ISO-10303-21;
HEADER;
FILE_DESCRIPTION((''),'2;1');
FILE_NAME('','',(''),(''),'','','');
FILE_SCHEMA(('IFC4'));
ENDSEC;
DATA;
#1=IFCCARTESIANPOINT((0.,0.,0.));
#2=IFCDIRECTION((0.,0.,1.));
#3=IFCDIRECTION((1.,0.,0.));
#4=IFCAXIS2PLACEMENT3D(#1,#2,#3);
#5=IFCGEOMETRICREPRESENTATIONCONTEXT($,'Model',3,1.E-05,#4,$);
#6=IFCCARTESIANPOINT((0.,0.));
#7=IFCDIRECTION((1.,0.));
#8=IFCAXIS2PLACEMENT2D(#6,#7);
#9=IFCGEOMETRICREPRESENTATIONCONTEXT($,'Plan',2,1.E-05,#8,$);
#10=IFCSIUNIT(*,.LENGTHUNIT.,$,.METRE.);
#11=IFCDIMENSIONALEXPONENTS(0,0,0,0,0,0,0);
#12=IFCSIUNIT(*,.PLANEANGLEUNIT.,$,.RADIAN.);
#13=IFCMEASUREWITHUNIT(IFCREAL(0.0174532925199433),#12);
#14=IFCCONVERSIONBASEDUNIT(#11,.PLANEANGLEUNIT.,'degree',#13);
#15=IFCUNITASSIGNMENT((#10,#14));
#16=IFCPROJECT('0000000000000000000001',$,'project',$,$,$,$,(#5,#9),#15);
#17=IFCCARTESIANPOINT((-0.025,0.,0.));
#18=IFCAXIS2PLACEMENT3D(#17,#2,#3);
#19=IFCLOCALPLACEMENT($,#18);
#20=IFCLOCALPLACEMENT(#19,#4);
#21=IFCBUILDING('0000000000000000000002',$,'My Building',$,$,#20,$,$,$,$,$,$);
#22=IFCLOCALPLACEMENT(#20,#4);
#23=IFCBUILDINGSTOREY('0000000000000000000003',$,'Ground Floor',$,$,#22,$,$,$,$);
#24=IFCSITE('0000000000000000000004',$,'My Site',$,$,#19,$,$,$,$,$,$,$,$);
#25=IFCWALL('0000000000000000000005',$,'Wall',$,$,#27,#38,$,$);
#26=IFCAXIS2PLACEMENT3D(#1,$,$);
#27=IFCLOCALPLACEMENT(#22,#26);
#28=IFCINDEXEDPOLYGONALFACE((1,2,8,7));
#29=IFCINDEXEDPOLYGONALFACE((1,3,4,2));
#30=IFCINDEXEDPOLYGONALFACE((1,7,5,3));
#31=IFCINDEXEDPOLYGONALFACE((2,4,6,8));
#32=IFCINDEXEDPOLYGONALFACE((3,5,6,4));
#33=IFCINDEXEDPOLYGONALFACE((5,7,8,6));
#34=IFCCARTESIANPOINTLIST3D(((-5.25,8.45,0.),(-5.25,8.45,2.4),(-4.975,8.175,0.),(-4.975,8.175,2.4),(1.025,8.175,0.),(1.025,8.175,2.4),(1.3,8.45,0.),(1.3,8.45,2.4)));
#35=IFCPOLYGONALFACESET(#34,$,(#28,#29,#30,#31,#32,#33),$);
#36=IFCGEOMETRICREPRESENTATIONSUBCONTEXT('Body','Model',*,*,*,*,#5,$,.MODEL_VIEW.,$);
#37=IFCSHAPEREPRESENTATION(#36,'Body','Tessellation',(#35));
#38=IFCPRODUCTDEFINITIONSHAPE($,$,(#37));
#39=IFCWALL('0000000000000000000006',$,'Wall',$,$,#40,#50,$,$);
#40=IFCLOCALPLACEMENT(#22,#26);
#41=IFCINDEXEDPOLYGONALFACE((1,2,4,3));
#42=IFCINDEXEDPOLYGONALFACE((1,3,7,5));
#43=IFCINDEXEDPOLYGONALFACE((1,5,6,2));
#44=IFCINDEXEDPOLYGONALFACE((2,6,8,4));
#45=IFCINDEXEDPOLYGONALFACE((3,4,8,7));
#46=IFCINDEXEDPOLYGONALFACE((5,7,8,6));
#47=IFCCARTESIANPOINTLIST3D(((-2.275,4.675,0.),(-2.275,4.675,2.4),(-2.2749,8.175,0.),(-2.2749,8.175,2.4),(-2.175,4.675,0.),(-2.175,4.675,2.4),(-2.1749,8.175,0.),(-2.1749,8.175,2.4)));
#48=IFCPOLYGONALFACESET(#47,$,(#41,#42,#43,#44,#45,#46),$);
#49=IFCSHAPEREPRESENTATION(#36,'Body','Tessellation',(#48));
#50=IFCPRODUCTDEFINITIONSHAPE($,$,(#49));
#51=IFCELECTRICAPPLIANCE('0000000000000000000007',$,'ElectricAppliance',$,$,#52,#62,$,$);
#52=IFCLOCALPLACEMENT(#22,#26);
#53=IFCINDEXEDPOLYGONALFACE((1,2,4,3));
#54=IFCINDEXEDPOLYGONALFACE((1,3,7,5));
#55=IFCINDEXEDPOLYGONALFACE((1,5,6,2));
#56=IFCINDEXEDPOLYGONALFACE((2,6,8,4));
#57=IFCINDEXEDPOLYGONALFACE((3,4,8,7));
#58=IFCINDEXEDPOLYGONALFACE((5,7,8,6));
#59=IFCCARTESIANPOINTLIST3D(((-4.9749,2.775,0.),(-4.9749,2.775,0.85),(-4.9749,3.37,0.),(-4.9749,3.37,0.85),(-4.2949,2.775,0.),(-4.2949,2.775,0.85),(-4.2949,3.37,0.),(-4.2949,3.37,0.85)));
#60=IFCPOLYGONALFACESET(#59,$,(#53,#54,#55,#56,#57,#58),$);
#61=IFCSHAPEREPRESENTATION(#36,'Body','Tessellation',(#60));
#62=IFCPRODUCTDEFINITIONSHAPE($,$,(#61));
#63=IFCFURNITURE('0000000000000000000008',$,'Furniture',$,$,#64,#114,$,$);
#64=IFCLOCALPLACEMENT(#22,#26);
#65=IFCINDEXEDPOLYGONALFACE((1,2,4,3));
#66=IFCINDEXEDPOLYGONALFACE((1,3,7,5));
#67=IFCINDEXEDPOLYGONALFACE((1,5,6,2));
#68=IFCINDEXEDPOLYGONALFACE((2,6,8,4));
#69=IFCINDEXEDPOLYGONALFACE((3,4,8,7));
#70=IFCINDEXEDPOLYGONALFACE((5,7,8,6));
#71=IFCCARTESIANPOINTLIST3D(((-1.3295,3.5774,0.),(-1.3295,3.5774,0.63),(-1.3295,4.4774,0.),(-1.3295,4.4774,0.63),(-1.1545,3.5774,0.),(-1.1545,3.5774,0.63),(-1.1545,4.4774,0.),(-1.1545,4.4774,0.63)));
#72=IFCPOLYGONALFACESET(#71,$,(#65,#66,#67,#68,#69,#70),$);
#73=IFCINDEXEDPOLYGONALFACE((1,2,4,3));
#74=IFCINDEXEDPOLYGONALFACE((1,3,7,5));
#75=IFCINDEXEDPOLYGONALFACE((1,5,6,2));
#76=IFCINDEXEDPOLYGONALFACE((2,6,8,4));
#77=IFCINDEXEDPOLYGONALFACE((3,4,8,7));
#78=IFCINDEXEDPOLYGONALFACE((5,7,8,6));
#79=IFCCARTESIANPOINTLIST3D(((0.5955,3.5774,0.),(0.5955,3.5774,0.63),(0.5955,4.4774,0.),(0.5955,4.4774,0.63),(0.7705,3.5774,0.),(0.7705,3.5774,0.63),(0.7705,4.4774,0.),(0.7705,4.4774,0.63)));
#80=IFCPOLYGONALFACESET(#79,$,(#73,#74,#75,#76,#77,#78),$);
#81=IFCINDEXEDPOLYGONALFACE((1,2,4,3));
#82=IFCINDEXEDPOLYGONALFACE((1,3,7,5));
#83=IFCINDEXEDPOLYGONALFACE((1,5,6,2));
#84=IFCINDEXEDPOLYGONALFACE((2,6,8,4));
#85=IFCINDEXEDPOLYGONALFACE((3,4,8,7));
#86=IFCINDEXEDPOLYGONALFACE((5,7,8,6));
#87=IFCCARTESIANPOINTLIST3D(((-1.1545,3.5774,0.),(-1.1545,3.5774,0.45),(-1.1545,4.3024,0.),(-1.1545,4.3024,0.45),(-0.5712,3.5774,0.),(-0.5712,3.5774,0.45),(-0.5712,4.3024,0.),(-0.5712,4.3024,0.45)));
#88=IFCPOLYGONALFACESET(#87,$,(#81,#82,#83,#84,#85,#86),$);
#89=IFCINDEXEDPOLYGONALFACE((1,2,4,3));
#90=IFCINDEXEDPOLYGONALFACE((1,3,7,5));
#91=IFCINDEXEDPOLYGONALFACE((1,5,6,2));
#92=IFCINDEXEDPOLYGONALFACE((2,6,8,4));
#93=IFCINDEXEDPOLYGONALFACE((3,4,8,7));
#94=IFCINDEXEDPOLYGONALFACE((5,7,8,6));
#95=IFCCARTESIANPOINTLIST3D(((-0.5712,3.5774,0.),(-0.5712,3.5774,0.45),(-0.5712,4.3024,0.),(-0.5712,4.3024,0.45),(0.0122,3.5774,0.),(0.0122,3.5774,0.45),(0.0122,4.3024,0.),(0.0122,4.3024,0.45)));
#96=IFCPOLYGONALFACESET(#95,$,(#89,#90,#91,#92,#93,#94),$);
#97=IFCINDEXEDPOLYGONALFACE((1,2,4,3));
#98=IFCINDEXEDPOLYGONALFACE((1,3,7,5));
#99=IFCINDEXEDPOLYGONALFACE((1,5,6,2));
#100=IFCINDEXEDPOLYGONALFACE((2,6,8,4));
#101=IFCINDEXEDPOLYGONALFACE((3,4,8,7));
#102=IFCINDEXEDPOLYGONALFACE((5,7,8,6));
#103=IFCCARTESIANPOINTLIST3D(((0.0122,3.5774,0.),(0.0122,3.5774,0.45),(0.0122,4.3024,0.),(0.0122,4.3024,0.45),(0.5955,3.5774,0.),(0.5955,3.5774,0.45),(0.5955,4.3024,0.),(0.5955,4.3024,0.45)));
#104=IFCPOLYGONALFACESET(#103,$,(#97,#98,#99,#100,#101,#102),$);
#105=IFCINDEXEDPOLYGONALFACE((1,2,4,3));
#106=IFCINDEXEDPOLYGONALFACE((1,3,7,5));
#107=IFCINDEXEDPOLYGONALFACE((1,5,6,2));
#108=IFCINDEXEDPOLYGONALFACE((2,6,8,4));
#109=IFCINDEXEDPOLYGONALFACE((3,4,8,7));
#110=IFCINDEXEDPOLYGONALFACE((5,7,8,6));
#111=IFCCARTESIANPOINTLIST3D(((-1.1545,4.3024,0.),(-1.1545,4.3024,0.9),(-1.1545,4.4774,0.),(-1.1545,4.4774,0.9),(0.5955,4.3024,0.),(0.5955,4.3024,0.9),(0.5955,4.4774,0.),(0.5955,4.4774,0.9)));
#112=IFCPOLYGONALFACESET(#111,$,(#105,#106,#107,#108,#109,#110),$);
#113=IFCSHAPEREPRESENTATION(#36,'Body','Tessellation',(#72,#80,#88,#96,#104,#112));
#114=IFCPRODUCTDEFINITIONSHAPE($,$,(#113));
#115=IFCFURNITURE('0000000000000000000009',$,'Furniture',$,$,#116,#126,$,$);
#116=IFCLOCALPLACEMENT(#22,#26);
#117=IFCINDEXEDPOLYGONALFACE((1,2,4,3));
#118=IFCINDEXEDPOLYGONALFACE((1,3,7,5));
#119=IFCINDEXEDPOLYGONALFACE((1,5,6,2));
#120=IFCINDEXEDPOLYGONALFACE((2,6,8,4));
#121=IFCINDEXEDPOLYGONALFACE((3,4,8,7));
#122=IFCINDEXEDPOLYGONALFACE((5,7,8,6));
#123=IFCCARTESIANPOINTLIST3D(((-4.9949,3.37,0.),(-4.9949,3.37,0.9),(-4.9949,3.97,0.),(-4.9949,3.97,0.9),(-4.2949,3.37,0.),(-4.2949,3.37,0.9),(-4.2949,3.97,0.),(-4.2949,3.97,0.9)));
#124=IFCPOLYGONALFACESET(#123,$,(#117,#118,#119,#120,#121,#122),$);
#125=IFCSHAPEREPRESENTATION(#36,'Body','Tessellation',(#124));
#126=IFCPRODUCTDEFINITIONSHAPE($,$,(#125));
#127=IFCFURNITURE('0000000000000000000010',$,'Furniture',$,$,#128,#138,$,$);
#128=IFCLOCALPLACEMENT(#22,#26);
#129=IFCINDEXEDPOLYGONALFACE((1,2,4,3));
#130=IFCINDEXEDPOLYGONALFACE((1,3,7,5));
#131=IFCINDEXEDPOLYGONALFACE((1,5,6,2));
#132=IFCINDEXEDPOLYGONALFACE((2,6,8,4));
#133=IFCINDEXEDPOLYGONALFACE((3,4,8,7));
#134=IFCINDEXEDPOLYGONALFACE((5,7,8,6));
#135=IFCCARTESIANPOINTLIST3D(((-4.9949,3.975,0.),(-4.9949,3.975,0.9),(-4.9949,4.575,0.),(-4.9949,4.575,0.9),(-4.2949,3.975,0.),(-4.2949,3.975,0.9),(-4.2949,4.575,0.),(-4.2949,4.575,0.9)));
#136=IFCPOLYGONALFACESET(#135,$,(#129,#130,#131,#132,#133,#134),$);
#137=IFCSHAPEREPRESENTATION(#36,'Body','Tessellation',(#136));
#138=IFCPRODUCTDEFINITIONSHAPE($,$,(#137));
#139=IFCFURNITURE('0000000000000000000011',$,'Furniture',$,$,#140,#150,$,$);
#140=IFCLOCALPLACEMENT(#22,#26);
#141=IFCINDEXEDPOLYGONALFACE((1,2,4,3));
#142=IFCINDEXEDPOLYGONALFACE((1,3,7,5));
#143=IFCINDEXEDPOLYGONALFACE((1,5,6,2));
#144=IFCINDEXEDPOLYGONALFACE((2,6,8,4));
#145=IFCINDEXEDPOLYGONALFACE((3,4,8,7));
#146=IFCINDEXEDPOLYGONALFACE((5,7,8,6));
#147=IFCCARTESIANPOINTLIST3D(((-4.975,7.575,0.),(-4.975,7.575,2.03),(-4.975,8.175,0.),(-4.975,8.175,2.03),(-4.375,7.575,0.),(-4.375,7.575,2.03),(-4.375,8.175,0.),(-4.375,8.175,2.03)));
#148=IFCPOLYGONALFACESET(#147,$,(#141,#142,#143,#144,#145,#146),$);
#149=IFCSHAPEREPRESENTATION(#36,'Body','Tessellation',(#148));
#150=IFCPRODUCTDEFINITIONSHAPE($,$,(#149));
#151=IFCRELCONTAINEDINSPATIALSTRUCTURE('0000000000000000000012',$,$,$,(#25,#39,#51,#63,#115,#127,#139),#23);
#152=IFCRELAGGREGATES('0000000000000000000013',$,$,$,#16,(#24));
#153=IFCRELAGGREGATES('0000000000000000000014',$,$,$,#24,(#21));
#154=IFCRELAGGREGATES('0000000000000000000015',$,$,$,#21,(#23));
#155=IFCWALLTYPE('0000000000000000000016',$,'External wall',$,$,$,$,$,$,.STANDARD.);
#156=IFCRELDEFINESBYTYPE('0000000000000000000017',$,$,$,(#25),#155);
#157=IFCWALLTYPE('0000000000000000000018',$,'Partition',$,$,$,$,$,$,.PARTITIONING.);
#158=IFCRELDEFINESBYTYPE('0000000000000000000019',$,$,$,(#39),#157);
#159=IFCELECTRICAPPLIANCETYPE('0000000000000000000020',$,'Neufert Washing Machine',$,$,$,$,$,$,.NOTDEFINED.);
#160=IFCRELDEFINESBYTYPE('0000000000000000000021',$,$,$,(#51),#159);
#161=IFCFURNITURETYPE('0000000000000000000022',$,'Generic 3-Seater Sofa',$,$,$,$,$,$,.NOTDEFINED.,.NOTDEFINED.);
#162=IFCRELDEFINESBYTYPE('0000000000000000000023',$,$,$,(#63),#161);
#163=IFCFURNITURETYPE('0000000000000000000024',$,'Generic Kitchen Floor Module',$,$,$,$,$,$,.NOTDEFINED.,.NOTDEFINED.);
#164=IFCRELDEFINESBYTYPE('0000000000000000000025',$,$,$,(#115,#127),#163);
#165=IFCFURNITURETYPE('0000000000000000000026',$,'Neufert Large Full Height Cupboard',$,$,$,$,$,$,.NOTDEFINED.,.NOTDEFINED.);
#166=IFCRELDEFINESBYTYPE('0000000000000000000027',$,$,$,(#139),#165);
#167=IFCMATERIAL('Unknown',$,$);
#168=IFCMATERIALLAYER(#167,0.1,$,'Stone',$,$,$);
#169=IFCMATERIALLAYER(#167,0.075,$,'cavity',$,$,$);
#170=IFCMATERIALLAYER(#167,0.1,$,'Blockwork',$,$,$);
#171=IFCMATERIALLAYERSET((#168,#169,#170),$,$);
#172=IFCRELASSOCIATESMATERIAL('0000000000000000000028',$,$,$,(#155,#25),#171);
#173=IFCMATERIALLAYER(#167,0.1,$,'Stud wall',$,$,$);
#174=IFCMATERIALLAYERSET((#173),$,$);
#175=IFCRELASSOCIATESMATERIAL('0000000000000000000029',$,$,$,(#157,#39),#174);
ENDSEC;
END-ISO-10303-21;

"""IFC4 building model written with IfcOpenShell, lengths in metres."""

from ifc_helpers import new_model, entity, si_unit, converted_unit, frame, origin_with_axes, origin_2d_with_axis, place, context, subcontext, project, spatial, line, indexed_curve, outline, extrude, clip, halfspace, shape, source, transform, mapped, material, layer, layer_set, layer_usage, type_object, type_shapes, element, save


model = new_model("IFC4")

# Units and contexts
model_context = context("Model", 3, precision=1e-05, world=origin_with_axes())
plan_context = context("Plan", 2, precision=1e-05, world=origin_2d_with_axis())
body_context_1 = subcontext(model_context, "Body", "Model", "MODEL_VIEW")
body_context_2 = subcontext(plan_context, "Body", "Plan", "PLAN_VIEW")
ifc_project = project(units=[si_unit("LENGTHUNIT", "METRE"), converted_unit("PLANEANGLEUNIT", "degree", entity("IfcReal", 0.0174532925199433), si_unit("PLANEANGLEUNIT", "RADIAN"), dimensions=[0, 0, 0, 0, 0, 0, 0])], contexts=[model_context, plan_context])

# Site, building, storey
site_placement = place(None, frame((-0.025, 0.0, 0.0), z_axis=(0.0, 0.0, 1.0), x_axis=(1.0, 0.0, 0.0)))
site = spatial("IfcSite", under=ifc_project, at=site_placement, Name="My Site")
building_placement = place(site_placement, origin_with_axes())
building = spatial("IfcBuilding", under=site, at=building_placement, Name="My Building")
storey_placement = place(building_placement, frame((0.0, 0.0, 0.0), z_axis=(0.0, 0.0, 1.0), x_axis=(1.0, 0.0, 0.0)))
storey = spatial("IfcBuildingStorey", under=building, at=storey_placement, Name="Ground Floor")

# Wall
ifc_material = material(Name="Unknown")
ifc_layer_1 = layer(ifc_material, 0.1, Name="Stone")
ifc_layer_2 = layer(ifc_material, 0.075, Name="cavity")
ifc_layer_3 = layer(ifc_material, 0.1, Name="Blockwork")
ifc_layer_set_1 = layer_set([ifc_layer_1, ifc_layer_2, ifc_layer_3])
ifc_layer_usage_1 = layer_usage(ifc_layer_set_1, "AXIS2", "POSITIVE", 0.0)
wall_type_1 = type_object("IfcWallType", Name="External wall", PredefinedType="STANDARD", material=ifc_layer_set_1)
wall_1_placement = place(storey_placement, frame((1.3, 8.45, 0.0), z_axis=(0.0, 0.0, 1.0), x_axis=(-1.0, 0.0, 0.0)))
element("IfcWall", 1, at=wall_1_placement, inside=storey, type_object=wall_type_1, material=ifc_layer_usage_1, Name="Wall", context=body_context_1, shape_type="Clipping", body=[
    clip(clip(extrude(outline(indexed_curve([(0.0, 0.0), (0.0, 0.275), (6.55, 0.275), (6.55, 0.0), (0.0, 0.0)], self_intersect=False)), origin_with_axes(), (0.0, 0.0, 1.0), 2.4), halfspace(frame((6.55, 0.0, 0.0), z_axis=(0.707106, 0.707107, 0.0), x_axis=(0.707107, -0.707106, 0.0)), False)), halfspace(frame((0.0, 0.0, 0.0), z_axis=(-0.707106, 0.707107, 0.0), x_axis=(0.707108, 0.707106, 0.0)), False)),
])

# Shared definitions
ifc_layer_4 = layer(ifc_material, 0.1, Name="Stud wall")
ifc_layer_set_2 = layer_set([ifc_layer_4])
wall_type_2 = type_object("IfcWallType", Name="Partition", PredefinedType="PARTITIONING", material=ifc_layer_set_2)

# Wall
ifc_layer_usage_2 = layer_usage(ifc_layer_set_2, "AXIS2", "POSITIVE", 0.0)
wall_2_placement = place(storey_placement, frame((-2.175, 4.675, 0.0), z_axis=(0.0, 0.0, 1.0), x_axis=(0.0, 1.0, 0.0)))
element("IfcWall", 2, at=wall_2_placement, inside=storey, type_object=wall_type_2, material=ifc_layer_usage_2, Name="Wall", context=body_context_1, shape_type="SweptSolid", body=[
    extrude(outline(indexed_curve([(0.0, 0.0), (0.0, 0.1), (3.5, 0.1), (3.5, 0.0), (0.0, 0.0)], self_intersect=False)), origin_with_axes(), (0.0, 0.0, 1.0), 2.4),
])

# Electric appliance
electric_appliance_type_1 = type_object("IfcElectricApplianceType", Name="Neufert Washing Machine", PredefinedType="NOTDEFINED")
shared_shape_1 = source(origin_with_axes(), body_context_1, "Body", "SweptSolid", [
    extrude(outline(indexed_curve([(0.0, 0.0), (0.595, 0.0), (0.595, 0.68), (0.0, 0.68)], segments=[line(1, 2, 3, 4, 1)])), origin_with_axes(), (0.0, 0.0, 1.0), 0.85),
])
shared_shape_2 = source(origin_with_axes(), body_context_2, "Body", "Curve2D", [
    entity("IfcIndexedPolyCurve", entity("IfcCartesianPointList2D", [[0.0, 0.0], [0.595, 0.0], [0.595, 0.68], [0.0, 0.68]]), [entity("IfcLineIndex", [1, 2, 3, 4, 1])]),
    entity("IfcCircle", entity("IfcAxis2Placement2D", entity("IfcCartesianPoint", [0.2975, 0.34])), 0.1785),
    entity("IfcCircle", entity("IfcAxis2Placement2D", entity("IfcCartesianPoint", [0.2975, 0.34])), 0.0595),
])
type_shapes(electric_appliance_type_1, [shared_shape_1, shared_shape_2])
electric_appliance_1_placement = place(storey_placement, frame((-4.2949, 2.775, 0.0), z_axis=(0.0, 0.0, 1.0), x_axis=(0.0, 1.0, 0.0)))
element("IfcElectricAppliance", 3, at=electric_appliance_1_placement, inside=storey, type_object=electric_appliance_type_1, Name="ElectricAppliance", shapes=[
    shape(body_context_1, "Body", "MappedRepresentation", [mapped(shared_shape_1, transform((0.0, 0.0, 0.0), x_axis=(1.0, 0.0, 0.0), y_axis=(0.0, 1.0, 0.0), z_axis=(0.0, 0.0, 1.0), scale=1.0))]),
    shape(body_context_2, "Body", "MappedRepresentation", [mapped(shared_shape_2, transform((0.0, 0.0, 0.0), x_axis=(1.0, 0.0, 0.0), y_axis=(0.0, 1.0, 0.0), z_axis=(0.0, 0.0, 1.0), scale=1.0))]),
])

# Furniture
furniture_type_1 = type_object("IfcFurnitureType", Name="Generic 3-Seater Sofa", AssemblyPlace="NOTDEFINED", PredefinedType="NOTDEFINED")
shared_shape_3 = source(origin_with_axes(), body_context_1, "Body", "SweptSolid", [
    extrude(outline(indexed_curve([(0.0, 0.0), (0.175, 0.0), (0.175, 0.9), (0.0, 0.9)], segments=[line(1, 2, 3, 4, 1)])), frame((-1.05, -0.9, 0.0), z_axis=(0.0, 0.0, 1.0), x_axis=(1.0, 0.0, 0.0)), (0.0, 0.0, 1.0), 0.63),
    extrude(outline(indexed_curve([(0.0, 0.0), (0.175, 0.0), (0.175, 0.9), (0.0, 0.9)], segments=[line(1, 2, 3, 4, 1)])), frame((0.875, -0.9, 0.0), z_axis=(0.0, 0.0, 1.0), x_axis=(1.0, 0.0, 0.0)), (0.0, 0.0, 1.0), 0.63),
    extrude(outline(indexed_curve([(0.175, 0.0), (0.7583, 0.0), (0.7583, 0.725), (0.175, 0.725)], segments=[line(1, 2, 3, 4, 1)])), frame((-1.05, -0.9, 0.0), z_axis=(0.0, 0.0, 1.0), x_axis=(1.0, 0.0, 0.0)), (0.0, 0.0, 1.0), 0.45),
    extrude(outline(indexed_curve([(0.7583, 0.0), (1.3417, 0.0), (1.3417, 0.725), (0.7583, 0.725)], segments=[line(1, 2, 3, 4, 1)])), frame((-1.05, -0.9, 0.0), z_axis=(0.0, 0.0, 1.0), x_axis=(1.0, 0.0, 0.0)), (0.0, 0.0, 1.0), 0.45),
    extrude(outline(indexed_curve([(1.3417, 0.0), (1.925, 0.0), (1.925, 0.725), (1.3417, 0.725)], segments=[line(1, 2, 3, 4, 1)])), frame((-1.05, -0.9, 0.0), z_axis=(0.0, 0.0, 1.0), x_axis=(1.0, 0.0, 0.0)), (0.0, 0.0, 1.0), 0.45),
    extrude(outline(indexed_curve([(0.175, 0.725), (1.925, 0.725), (1.925, 0.9), (0.175, 0.9)], segments=[line(1, 2, 3, 4, 1)])), frame((-1.05, -0.9, 0.0), z_axis=(0.0, 0.0, 1.0), x_axis=(1.0, 0.0, 0.0)), (0.0, 0.0, 1.0), 0.9),
])
shared_shape_4 = source(origin_with_axes(), body_context_2, "Body", "Curve2D", [
    entity("IfcIndexedPolyCurve", entity("IfcCartesianPointList2D", [[-1.05, -0.9], [-0.875, -0.9], [-0.875, 0.0], [-1.05, 0.0]]), [entity("IfcLineIndex", [1, 2, 3, 4, 1])]),
    entity("IfcIndexedPolyCurve", entity("IfcCartesianPointList2D", [[0.875, -0.9], [1.05, -0.9], [1.05, 0.0], [0.875, 0.0]]), [entity("IfcLineIndex", [1, 2, 3, 4, 1])]),
    entity("IfcIndexedPolyCurve", entity("IfcCartesianPointList2D", [[-0.875, -0.9], [-0.2917, -0.9], [-0.2917, -0.175], [-0.875, -0.175]]), [entity("IfcLineIndex", [1, 2, 3, 4, 1])]),
    entity("IfcIndexedPolyCurve", entity("IfcCartesianPointList2D", [[-0.2917, -0.9], [0.2917, -0.9], [0.2917, -0.175], [-0.2917, -0.175]]), [entity("IfcLineIndex", [1, 2, 3, 4, 1])]),
    entity("IfcIndexedPolyCurve", entity("IfcCartesianPointList2D", [[0.2917, -0.9], [0.875, -0.9], [0.875, -0.175], [0.2917, -0.175]]), [entity("IfcLineIndex", [1, 2, 3, 4, 1])]),
    entity("IfcIndexedPolyCurve", entity("IfcCartesianPointList2D", [[-0.875, -0.175], [0.875, -0.175], [0.875, 0.0], [-0.875, 0.0]]), [entity("IfcLineIndex", [1, 2, 3, 4, 1])]),
])
type_shapes(furniture_type_1, [shared_shape_3, shared_shape_4])
furniture_1_placement = place(storey_placement, frame((-0.2795, 4.4774, 0.0), z_axis=(0.0, 0.0, 1.0), x_axis=(1.0, 0.0, 0.0)))
element("IfcFurniture", 4, at=furniture_1_placement, inside=storey, type_object=furniture_type_1, Name="Furniture", shapes=[
    shape(body_context_1, "Body", "MappedRepresentation", [mapped(shared_shape_3, transform((0.0, 0.0, 0.0), x_axis=(1.0, 0.0, 0.0), y_axis=(0.0, 1.0, 0.0), z_axis=(0.0, 0.0, 1.0), scale=1.0))]),
    shape(body_context_2, "Body", "MappedRepresentation", [mapped(shared_shape_4, transform((0.0, 0.0, 0.0), x_axis=(1.0, 0.0, 0.0), y_axis=(0.0, 1.0, 0.0), z_axis=(0.0, 0.0, 1.0), scale=1.0))]),
])
furniture_type_2 = type_object("IfcFurnitureType", Name="Generic Kitchen Floor Module", AssemblyPlace="NOTDEFINED", PredefinedType="NOTDEFINED")
shared_shape_5 = source(origin_with_axes(), body_context_1, "Body", "SweptSolid", [
    extrude(outline(indexed_curve([(0.0, 0.0), (0.6, 0.0), (0.6, 0.7), (0.0, 0.7)], segments=[line(1, 2, 3, 4, 1)])), origin_with_axes(), (0.0, 0.0, 1.0), 0.9),
])
shared_shape_6 = source(origin_with_axes(), body_context_2, "Body", "Curve2D", [
    entity("IfcIndexedPolyCurve", entity("IfcCartesianPointList2D", [[0.0, 0.0], [0.6, 0.0], [0.6, 0.7], [0.0, 0.7]]), [entity("IfcLineIndex", [1, 2, 3, 4, 1])]),
])
type_shapes(furniture_type_2, [shared_shape_5, shared_shape_6])
for number, where, z_axis, x_axis, name in (
    (5, (-4.2949, 3.37, 0.0), (0.0, 0.0, 1.0), (0.0, 1.0, 0.0), "Furniture"),
    (6, (-4.2949, 3.975, 0.0), (0.0, 0.0, 1.0), (0.0, 1.0, 0.0), "Furniture"),
):
    element("IfcFurniture", number, at=place(storey_placement, frame(where, z_axis=z_axis, x_axis=x_axis)), inside=storey, type_object=furniture_type_2, Name=name, shapes=[
        shape(body_context_1, "Body", "MappedRepresentation", [mapped(shared_shape_5, transform((0.0, 0.0, 0.0), x_axis=(1.0, 0.0, 0.0), y_axis=(0.0, 1.0, 0.0), z_axis=(0.0, 0.0, 1.0), scale=1.0))]),
        shape(body_context_2, "Body", "MappedRepresentation", [mapped(shared_shape_6, transform((0.0, 0.0, 0.0), x_axis=(1.0, 0.0, 0.0), y_axis=(0.0, 1.0, 0.0), z_axis=(0.0, 0.0, 1.0), scale=1.0))]),
    ])
furniture_type_3 = type_object("IfcFurnitureType", Name="Neufert Large Full Height Cupboard", AssemblyPlace="NOTDEFINED", PredefinedType="NOTDEFINED")
shared_shape_7 = source(origin_with_axes(), body_context_1, "Body", "SweptSolid", [
    extrude(outline(indexed_curve([(0.0, 0.0), (0.6, 0.0), (0.6, 0.6), (0.0, 0.6)], segments=[line(1, 2, 3, 4, 1)])), origin_with_axes(), (0.0, 0.0, 1.0), 2.03),
])
shared_shape_8 = source(origin_with_axes(), body_context_2, "Body", "Curve2D", [
    entity("IfcIndexedPolyCurve", entity("IfcCartesianPointList2D", [[0.0, 0.0], [0.6, 0.0], [0.6, 0.6], [0.0, 0.6]]), [entity("IfcLineIndex", [1, 2, 3, 4, 1])]),
])
type_shapes(furniture_type_3, [shared_shape_7, shared_shape_8])
furniture_2_placement = place(storey_placement, frame((-4.975, 7.575, 0.0), z_axis=(0.0, 0.0, 1.0), x_axis=(1.0, 0.0, 0.0)))
element("IfcFurniture", 7, at=furniture_2_placement, inside=storey, type_object=furniture_type_3, Name="Furniture", shapes=[
    shape(body_context_1, "Body", "MappedRepresentation", [mapped(shared_shape_7, transform((0.0, 0.0, 0.0), x_axis=(1.0, 0.0, 0.0), y_axis=(0.0, 1.0, 0.0), z_axis=(0.0, 0.0, 1.0), scale=1.0))]),
    shape(body_context_2, "Body", "MappedRepresentation", [mapped(shared_shape_8, transform((0.0, 0.0, 0.0), x_axis=(1.0, 0.0, 0.0), y_axis=(0.0, 1.0, 0.0), z_axis=(0.0, 0.0, 1.0), scale=1.0))]),
])

save(model, "model.ifc")
